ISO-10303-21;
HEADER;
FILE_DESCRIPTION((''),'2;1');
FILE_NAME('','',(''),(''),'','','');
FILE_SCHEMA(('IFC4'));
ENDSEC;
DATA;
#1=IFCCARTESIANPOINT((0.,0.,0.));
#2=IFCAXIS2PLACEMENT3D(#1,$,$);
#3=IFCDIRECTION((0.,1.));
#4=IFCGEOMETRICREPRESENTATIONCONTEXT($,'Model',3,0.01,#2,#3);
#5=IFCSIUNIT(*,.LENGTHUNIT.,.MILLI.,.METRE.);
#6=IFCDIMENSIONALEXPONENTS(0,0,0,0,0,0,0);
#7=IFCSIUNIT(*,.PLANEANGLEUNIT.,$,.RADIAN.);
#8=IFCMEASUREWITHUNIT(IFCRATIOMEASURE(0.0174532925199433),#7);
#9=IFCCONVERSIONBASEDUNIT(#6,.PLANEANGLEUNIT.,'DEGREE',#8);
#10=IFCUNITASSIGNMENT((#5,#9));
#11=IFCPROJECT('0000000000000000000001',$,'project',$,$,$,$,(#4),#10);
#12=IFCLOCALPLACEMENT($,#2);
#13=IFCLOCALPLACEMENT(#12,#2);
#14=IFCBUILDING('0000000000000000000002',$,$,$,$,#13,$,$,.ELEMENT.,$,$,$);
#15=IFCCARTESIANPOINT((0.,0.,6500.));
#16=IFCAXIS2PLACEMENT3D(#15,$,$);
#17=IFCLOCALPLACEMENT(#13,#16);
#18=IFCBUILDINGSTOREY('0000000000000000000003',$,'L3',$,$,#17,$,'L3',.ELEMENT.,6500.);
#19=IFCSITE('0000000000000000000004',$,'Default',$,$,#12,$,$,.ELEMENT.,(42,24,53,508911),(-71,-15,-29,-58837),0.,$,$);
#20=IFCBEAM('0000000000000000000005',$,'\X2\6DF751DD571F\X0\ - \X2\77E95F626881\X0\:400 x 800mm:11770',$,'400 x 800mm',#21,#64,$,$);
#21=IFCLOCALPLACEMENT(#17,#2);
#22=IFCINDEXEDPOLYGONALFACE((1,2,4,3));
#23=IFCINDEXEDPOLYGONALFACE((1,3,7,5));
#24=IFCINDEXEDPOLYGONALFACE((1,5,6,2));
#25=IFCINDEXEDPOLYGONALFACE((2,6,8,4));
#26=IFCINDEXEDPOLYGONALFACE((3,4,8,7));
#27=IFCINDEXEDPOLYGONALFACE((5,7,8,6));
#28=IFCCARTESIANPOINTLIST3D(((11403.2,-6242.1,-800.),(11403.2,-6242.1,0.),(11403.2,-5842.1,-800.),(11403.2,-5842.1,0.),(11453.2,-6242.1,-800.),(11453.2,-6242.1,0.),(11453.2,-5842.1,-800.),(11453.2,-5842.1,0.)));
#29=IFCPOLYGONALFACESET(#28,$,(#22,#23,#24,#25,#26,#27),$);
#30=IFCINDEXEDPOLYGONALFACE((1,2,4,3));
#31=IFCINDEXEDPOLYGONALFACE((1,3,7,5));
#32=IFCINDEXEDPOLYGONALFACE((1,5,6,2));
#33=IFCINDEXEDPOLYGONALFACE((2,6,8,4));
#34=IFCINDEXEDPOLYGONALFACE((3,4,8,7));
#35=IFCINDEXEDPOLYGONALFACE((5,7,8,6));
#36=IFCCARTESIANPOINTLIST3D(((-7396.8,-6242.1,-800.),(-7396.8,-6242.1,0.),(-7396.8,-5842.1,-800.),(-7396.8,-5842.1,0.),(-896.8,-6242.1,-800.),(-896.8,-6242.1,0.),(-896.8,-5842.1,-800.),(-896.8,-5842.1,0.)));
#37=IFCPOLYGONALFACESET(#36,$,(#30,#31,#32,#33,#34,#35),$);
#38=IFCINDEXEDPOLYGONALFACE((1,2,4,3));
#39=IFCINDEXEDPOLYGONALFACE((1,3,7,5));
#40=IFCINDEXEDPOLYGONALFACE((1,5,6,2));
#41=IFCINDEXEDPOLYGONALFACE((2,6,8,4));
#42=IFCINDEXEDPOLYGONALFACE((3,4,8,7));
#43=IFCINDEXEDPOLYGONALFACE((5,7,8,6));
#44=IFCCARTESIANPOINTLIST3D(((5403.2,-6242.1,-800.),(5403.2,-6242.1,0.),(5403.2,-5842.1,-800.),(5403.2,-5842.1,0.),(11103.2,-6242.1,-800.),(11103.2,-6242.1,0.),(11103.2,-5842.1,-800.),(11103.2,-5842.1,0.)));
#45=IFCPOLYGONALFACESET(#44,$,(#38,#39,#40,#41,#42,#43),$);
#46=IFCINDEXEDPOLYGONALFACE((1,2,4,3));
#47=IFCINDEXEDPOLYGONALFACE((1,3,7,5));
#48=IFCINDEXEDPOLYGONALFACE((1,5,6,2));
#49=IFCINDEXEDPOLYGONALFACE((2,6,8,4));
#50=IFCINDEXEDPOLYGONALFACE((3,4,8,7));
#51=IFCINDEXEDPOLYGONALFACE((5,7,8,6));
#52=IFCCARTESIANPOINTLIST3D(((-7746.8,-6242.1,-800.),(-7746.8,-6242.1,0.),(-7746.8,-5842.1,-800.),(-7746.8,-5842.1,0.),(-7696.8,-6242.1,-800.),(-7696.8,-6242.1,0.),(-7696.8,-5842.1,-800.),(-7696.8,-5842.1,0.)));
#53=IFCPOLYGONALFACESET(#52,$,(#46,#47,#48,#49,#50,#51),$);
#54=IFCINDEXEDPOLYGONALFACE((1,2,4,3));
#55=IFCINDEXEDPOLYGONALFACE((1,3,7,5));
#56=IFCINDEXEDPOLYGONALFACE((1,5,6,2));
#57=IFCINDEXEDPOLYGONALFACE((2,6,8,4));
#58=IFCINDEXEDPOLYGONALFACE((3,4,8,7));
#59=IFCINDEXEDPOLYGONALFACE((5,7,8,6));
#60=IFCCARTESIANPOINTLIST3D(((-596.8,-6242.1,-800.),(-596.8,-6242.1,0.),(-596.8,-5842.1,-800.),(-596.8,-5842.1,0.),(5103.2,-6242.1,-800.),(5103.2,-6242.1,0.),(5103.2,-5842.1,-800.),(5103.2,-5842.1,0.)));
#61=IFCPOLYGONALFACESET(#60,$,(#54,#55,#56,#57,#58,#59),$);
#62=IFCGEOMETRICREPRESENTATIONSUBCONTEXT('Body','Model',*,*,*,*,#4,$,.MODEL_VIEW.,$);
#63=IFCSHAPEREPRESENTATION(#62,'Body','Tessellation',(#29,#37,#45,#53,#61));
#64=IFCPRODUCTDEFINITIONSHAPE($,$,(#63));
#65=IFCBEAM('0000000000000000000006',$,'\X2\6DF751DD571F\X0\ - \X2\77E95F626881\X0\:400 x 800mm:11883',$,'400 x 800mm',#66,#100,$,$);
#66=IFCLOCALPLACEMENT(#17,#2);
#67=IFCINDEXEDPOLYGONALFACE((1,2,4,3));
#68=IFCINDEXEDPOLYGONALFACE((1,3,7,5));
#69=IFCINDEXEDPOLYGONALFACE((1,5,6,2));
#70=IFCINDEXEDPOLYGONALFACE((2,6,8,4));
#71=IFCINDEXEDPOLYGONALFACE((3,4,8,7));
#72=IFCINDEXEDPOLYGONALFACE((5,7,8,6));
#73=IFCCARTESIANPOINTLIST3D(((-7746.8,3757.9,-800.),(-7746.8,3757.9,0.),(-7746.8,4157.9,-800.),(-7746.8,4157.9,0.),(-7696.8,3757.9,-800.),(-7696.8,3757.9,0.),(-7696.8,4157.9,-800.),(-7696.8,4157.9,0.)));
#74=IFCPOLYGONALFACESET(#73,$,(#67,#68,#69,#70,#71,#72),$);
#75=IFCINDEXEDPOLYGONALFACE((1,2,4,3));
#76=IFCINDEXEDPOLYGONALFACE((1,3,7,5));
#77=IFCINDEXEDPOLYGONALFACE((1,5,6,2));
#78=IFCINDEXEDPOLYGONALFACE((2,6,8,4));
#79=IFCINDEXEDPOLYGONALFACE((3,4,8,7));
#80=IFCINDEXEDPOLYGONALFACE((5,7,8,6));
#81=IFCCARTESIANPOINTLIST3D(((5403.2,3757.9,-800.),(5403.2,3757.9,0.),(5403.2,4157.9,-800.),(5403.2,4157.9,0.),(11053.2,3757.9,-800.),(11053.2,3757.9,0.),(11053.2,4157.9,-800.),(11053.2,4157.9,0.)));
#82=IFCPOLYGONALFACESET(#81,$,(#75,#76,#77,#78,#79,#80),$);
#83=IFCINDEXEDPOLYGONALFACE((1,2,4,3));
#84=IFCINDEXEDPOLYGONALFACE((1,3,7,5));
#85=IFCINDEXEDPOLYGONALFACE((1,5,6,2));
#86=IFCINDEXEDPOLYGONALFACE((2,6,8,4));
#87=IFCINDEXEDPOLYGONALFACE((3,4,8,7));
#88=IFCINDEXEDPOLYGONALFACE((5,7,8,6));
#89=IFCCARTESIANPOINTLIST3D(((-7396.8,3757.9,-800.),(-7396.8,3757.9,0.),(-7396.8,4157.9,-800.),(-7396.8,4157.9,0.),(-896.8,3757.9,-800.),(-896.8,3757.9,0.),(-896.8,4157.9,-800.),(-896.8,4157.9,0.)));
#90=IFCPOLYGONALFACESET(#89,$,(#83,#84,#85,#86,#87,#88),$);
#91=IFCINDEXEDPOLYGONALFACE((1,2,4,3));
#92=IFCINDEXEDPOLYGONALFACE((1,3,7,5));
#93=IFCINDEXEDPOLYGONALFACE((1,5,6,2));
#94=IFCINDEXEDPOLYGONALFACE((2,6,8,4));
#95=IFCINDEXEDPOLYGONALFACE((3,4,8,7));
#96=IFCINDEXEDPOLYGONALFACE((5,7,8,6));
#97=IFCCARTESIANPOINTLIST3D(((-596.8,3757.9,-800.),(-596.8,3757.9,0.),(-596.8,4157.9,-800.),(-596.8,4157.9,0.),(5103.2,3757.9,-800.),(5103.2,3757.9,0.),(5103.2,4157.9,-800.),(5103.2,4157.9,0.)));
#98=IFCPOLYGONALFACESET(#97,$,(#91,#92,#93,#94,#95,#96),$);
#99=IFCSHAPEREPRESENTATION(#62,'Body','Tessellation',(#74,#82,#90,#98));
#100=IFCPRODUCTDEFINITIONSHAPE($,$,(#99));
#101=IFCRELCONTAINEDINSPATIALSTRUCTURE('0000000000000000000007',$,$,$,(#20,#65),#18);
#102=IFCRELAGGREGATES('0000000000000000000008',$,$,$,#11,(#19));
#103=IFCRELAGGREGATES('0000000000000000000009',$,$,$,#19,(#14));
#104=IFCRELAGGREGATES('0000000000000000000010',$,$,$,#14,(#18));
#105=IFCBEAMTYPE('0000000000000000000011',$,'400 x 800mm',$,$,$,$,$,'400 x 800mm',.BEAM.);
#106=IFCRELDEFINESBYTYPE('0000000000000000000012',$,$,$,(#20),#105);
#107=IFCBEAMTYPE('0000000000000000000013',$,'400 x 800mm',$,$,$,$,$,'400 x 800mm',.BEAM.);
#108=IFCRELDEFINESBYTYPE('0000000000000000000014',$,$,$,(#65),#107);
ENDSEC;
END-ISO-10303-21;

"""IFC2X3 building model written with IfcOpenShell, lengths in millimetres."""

from ifc_helpers import new_model, entity, si_unit, converted_unit, direction, frame, frame_2d, origin, origin_2d_with_axis, place, context, subcontext, project, spatial, rectangle, extrude, source, transform, mapped, type_object, type_shapes, element, save


model = new_model("IFC2X3")

# Units and contexts
model_context = context("Model", 3, precision=0.01, world=origin(), true_north=direction((0.0, 1.0)))
body_context = subcontext(model_context, "Body", "Model", "MODEL_VIEW")
ifc_project = project(units=[si_unit("LENGTHUNIT", "METRE", prefix="MILLI"), converted_unit("PLANEANGLEUNIT", "DEGREE", entity("IfcRatioMeasure", 0.0174532925199433), si_unit("PLANEANGLEUNIT", "RADIAN"), dimensions=[0, 0, 0, 0, 0, 0, 0])], contexts=[model_context])

# Site, building, storey
site_placement = place(None, origin())
site = spatial("IfcSite", under=ifc_project, at=site_placement, Name="Default", CompositionType="ELEMENT", RefLatitude=(42, 24, 53, 508911), RefLongitude=(-71, -15, -29, -58837), RefElevation=0.0)
building_placement = place(site_placement, origin())
building = spatial("IfcBuilding", under=site, at=building_placement, CompositionType="ELEMENT")
storey_placement = place(building_placement, frame((0.0, 0.0, 6500.0)))
storey = spatial("IfcBuildingStorey", under=building, at=storey_placement, Name="L3", LongName="L3", CompositionType="ELEMENT", Elevation=6500.0)

# Beams
beam_type_1 = type_object("IfcBeamType", Name="400 x 800mm", ElementType="400 x 800mm", PredefinedType="BEAM")
shared_shape_1 = source(origin(), body_context, "Body", "SweptSolid", [
    extrude(rectangle(XDim=50.0, YDim=400.0, at=frame_2d((0.0, 0.0), x_axis=(1.0, 0.0))), frame((11428.2, -6042.1, 5700.0), z_axis=(0.0, 0.0, 1.0), x_axis=(-1.0, 0.0, 0.0)), (0.0, 0.0, 1.0), 800.0),
    extrude(rectangle(XDim=6500.0, YDim=400.0, at=frame_2d((640.0, -40.0), x_axis=(1.0, 0.0))), frame((-4786.8, -6002.1, 5700.0)), (0.0, 0.0, 1.0), 800.0),
    extrude(rectangle(XDim=5700.0, YDim=400.0, at=frame_2d((560.0, 40.0), x_axis=(1.0, 0.0))), frame((8813.2, -6002.1, 5700.0), z_axis=(0.0, 0.0, 1.0), x_axis=(-1.0, 0.0, 0.0)), (0.0, 0.0, 1.0), 800.0),
    extrude(rectangle(XDim=50.0, YDim=400.0, at=frame_2d((0.0, 0.0), x_axis=(1.0, 0.0))), frame((-7721.8, -6042.1, 5700.0)), (0.0, 0.0, 1.0), 800.0),
    extrude(rectangle(XDim=5700.0, YDim=400.0, at=frame_2d((0.0, 0.0), x_axis=(1.0, 0.0))), frame((2253.2, -6042.1, 5700.0), z_axis=(0.0, 0.0, 1.0), x_axis=(-1.0, 0.0, 0.0)), (0.0, 0.0, 1.0), 800.0),
])
type_shapes(beam_type_1, [shared_shape_1])
beam_1_placement = place(storey_placement, frame((0.0, 0.0, -6500.0)))
element("IfcBeam", 1, at=beam_1_placement, inside=storey, type_object=beam_type_1, Name="混凝土 - 矩形梁:400 x 800mm:11770", ObjectType="400 x 800mm", context=body_context, shape_type="MappedRepresentation", body=[
    mapped(shared_shape_1, transform((0.0, 0.0, 0.0), scale=1.0)),
])
beam_type_2 = type_object("IfcBeamType", Name="400 x 800mm", ElementType="400 x 800mm", PredefinedType="BEAM")
shared_shape_2 = source(origin(), body_context, "Body", "SweptSolid", [
    extrude(rectangle(XDim=50.0, YDim=400.0, at=frame_2d((0.0, 0.0), x_axis=(1.0, 0.0))), frame((-7721.8, 3957.9, 5700.0)), (0.0, 0.0, 1.0), 800.0),
    extrude(rectangle(XDim=5650.0, YDim=400.0, at=frame_2d((0.0, 0.0), x_axis=(1.0, 0.0))), frame((8228.2, 3957.9, 5700.0), z_axis=(0.0, 0.0, 1.0), x_axis=(-1.0, 0.0, 0.0)), (0.0, 0.0, 1.0), 800.0),
    extrude(rectangle(XDim=6500.0, YDim=400.0, at=frame_2d((640.0, 40.0), x_axis=(1.0, 0.0))), frame((-4786.8, 3917.9, 5700.0)), (0.0, 0.0, 1.0), 800.0),
    extrude(rectangle(XDim=5700.0, YDim=400.0, at=origin_2d_with_axis()), frame((2253.2, 3957.9, 5700.0), z_axis=(0.0, 0.0, 1.0), x_axis=(-1.0, 0.0, 0.0)), (0.0, 0.0, 1.0), 800.0),
])
type_shapes(beam_type_2, [shared_shape_2])
beam_2_placement = place(storey_placement, frame((0.0, 0.0, -6500.0)))
element("IfcBeam", 2, at=beam_2_placement, inside=storey, type_object=beam_type_2, Name="混凝土 - 矩形梁:400 x 800mm:11883", ObjectType="400 x 800mm", context=body_context, shape_type="MappedRepresentation", body=[
    mapped(shared_shape_2, transform((0.0, 0.0, 0.0), scale=1.0)),
])

save(model, "model.ifc")
